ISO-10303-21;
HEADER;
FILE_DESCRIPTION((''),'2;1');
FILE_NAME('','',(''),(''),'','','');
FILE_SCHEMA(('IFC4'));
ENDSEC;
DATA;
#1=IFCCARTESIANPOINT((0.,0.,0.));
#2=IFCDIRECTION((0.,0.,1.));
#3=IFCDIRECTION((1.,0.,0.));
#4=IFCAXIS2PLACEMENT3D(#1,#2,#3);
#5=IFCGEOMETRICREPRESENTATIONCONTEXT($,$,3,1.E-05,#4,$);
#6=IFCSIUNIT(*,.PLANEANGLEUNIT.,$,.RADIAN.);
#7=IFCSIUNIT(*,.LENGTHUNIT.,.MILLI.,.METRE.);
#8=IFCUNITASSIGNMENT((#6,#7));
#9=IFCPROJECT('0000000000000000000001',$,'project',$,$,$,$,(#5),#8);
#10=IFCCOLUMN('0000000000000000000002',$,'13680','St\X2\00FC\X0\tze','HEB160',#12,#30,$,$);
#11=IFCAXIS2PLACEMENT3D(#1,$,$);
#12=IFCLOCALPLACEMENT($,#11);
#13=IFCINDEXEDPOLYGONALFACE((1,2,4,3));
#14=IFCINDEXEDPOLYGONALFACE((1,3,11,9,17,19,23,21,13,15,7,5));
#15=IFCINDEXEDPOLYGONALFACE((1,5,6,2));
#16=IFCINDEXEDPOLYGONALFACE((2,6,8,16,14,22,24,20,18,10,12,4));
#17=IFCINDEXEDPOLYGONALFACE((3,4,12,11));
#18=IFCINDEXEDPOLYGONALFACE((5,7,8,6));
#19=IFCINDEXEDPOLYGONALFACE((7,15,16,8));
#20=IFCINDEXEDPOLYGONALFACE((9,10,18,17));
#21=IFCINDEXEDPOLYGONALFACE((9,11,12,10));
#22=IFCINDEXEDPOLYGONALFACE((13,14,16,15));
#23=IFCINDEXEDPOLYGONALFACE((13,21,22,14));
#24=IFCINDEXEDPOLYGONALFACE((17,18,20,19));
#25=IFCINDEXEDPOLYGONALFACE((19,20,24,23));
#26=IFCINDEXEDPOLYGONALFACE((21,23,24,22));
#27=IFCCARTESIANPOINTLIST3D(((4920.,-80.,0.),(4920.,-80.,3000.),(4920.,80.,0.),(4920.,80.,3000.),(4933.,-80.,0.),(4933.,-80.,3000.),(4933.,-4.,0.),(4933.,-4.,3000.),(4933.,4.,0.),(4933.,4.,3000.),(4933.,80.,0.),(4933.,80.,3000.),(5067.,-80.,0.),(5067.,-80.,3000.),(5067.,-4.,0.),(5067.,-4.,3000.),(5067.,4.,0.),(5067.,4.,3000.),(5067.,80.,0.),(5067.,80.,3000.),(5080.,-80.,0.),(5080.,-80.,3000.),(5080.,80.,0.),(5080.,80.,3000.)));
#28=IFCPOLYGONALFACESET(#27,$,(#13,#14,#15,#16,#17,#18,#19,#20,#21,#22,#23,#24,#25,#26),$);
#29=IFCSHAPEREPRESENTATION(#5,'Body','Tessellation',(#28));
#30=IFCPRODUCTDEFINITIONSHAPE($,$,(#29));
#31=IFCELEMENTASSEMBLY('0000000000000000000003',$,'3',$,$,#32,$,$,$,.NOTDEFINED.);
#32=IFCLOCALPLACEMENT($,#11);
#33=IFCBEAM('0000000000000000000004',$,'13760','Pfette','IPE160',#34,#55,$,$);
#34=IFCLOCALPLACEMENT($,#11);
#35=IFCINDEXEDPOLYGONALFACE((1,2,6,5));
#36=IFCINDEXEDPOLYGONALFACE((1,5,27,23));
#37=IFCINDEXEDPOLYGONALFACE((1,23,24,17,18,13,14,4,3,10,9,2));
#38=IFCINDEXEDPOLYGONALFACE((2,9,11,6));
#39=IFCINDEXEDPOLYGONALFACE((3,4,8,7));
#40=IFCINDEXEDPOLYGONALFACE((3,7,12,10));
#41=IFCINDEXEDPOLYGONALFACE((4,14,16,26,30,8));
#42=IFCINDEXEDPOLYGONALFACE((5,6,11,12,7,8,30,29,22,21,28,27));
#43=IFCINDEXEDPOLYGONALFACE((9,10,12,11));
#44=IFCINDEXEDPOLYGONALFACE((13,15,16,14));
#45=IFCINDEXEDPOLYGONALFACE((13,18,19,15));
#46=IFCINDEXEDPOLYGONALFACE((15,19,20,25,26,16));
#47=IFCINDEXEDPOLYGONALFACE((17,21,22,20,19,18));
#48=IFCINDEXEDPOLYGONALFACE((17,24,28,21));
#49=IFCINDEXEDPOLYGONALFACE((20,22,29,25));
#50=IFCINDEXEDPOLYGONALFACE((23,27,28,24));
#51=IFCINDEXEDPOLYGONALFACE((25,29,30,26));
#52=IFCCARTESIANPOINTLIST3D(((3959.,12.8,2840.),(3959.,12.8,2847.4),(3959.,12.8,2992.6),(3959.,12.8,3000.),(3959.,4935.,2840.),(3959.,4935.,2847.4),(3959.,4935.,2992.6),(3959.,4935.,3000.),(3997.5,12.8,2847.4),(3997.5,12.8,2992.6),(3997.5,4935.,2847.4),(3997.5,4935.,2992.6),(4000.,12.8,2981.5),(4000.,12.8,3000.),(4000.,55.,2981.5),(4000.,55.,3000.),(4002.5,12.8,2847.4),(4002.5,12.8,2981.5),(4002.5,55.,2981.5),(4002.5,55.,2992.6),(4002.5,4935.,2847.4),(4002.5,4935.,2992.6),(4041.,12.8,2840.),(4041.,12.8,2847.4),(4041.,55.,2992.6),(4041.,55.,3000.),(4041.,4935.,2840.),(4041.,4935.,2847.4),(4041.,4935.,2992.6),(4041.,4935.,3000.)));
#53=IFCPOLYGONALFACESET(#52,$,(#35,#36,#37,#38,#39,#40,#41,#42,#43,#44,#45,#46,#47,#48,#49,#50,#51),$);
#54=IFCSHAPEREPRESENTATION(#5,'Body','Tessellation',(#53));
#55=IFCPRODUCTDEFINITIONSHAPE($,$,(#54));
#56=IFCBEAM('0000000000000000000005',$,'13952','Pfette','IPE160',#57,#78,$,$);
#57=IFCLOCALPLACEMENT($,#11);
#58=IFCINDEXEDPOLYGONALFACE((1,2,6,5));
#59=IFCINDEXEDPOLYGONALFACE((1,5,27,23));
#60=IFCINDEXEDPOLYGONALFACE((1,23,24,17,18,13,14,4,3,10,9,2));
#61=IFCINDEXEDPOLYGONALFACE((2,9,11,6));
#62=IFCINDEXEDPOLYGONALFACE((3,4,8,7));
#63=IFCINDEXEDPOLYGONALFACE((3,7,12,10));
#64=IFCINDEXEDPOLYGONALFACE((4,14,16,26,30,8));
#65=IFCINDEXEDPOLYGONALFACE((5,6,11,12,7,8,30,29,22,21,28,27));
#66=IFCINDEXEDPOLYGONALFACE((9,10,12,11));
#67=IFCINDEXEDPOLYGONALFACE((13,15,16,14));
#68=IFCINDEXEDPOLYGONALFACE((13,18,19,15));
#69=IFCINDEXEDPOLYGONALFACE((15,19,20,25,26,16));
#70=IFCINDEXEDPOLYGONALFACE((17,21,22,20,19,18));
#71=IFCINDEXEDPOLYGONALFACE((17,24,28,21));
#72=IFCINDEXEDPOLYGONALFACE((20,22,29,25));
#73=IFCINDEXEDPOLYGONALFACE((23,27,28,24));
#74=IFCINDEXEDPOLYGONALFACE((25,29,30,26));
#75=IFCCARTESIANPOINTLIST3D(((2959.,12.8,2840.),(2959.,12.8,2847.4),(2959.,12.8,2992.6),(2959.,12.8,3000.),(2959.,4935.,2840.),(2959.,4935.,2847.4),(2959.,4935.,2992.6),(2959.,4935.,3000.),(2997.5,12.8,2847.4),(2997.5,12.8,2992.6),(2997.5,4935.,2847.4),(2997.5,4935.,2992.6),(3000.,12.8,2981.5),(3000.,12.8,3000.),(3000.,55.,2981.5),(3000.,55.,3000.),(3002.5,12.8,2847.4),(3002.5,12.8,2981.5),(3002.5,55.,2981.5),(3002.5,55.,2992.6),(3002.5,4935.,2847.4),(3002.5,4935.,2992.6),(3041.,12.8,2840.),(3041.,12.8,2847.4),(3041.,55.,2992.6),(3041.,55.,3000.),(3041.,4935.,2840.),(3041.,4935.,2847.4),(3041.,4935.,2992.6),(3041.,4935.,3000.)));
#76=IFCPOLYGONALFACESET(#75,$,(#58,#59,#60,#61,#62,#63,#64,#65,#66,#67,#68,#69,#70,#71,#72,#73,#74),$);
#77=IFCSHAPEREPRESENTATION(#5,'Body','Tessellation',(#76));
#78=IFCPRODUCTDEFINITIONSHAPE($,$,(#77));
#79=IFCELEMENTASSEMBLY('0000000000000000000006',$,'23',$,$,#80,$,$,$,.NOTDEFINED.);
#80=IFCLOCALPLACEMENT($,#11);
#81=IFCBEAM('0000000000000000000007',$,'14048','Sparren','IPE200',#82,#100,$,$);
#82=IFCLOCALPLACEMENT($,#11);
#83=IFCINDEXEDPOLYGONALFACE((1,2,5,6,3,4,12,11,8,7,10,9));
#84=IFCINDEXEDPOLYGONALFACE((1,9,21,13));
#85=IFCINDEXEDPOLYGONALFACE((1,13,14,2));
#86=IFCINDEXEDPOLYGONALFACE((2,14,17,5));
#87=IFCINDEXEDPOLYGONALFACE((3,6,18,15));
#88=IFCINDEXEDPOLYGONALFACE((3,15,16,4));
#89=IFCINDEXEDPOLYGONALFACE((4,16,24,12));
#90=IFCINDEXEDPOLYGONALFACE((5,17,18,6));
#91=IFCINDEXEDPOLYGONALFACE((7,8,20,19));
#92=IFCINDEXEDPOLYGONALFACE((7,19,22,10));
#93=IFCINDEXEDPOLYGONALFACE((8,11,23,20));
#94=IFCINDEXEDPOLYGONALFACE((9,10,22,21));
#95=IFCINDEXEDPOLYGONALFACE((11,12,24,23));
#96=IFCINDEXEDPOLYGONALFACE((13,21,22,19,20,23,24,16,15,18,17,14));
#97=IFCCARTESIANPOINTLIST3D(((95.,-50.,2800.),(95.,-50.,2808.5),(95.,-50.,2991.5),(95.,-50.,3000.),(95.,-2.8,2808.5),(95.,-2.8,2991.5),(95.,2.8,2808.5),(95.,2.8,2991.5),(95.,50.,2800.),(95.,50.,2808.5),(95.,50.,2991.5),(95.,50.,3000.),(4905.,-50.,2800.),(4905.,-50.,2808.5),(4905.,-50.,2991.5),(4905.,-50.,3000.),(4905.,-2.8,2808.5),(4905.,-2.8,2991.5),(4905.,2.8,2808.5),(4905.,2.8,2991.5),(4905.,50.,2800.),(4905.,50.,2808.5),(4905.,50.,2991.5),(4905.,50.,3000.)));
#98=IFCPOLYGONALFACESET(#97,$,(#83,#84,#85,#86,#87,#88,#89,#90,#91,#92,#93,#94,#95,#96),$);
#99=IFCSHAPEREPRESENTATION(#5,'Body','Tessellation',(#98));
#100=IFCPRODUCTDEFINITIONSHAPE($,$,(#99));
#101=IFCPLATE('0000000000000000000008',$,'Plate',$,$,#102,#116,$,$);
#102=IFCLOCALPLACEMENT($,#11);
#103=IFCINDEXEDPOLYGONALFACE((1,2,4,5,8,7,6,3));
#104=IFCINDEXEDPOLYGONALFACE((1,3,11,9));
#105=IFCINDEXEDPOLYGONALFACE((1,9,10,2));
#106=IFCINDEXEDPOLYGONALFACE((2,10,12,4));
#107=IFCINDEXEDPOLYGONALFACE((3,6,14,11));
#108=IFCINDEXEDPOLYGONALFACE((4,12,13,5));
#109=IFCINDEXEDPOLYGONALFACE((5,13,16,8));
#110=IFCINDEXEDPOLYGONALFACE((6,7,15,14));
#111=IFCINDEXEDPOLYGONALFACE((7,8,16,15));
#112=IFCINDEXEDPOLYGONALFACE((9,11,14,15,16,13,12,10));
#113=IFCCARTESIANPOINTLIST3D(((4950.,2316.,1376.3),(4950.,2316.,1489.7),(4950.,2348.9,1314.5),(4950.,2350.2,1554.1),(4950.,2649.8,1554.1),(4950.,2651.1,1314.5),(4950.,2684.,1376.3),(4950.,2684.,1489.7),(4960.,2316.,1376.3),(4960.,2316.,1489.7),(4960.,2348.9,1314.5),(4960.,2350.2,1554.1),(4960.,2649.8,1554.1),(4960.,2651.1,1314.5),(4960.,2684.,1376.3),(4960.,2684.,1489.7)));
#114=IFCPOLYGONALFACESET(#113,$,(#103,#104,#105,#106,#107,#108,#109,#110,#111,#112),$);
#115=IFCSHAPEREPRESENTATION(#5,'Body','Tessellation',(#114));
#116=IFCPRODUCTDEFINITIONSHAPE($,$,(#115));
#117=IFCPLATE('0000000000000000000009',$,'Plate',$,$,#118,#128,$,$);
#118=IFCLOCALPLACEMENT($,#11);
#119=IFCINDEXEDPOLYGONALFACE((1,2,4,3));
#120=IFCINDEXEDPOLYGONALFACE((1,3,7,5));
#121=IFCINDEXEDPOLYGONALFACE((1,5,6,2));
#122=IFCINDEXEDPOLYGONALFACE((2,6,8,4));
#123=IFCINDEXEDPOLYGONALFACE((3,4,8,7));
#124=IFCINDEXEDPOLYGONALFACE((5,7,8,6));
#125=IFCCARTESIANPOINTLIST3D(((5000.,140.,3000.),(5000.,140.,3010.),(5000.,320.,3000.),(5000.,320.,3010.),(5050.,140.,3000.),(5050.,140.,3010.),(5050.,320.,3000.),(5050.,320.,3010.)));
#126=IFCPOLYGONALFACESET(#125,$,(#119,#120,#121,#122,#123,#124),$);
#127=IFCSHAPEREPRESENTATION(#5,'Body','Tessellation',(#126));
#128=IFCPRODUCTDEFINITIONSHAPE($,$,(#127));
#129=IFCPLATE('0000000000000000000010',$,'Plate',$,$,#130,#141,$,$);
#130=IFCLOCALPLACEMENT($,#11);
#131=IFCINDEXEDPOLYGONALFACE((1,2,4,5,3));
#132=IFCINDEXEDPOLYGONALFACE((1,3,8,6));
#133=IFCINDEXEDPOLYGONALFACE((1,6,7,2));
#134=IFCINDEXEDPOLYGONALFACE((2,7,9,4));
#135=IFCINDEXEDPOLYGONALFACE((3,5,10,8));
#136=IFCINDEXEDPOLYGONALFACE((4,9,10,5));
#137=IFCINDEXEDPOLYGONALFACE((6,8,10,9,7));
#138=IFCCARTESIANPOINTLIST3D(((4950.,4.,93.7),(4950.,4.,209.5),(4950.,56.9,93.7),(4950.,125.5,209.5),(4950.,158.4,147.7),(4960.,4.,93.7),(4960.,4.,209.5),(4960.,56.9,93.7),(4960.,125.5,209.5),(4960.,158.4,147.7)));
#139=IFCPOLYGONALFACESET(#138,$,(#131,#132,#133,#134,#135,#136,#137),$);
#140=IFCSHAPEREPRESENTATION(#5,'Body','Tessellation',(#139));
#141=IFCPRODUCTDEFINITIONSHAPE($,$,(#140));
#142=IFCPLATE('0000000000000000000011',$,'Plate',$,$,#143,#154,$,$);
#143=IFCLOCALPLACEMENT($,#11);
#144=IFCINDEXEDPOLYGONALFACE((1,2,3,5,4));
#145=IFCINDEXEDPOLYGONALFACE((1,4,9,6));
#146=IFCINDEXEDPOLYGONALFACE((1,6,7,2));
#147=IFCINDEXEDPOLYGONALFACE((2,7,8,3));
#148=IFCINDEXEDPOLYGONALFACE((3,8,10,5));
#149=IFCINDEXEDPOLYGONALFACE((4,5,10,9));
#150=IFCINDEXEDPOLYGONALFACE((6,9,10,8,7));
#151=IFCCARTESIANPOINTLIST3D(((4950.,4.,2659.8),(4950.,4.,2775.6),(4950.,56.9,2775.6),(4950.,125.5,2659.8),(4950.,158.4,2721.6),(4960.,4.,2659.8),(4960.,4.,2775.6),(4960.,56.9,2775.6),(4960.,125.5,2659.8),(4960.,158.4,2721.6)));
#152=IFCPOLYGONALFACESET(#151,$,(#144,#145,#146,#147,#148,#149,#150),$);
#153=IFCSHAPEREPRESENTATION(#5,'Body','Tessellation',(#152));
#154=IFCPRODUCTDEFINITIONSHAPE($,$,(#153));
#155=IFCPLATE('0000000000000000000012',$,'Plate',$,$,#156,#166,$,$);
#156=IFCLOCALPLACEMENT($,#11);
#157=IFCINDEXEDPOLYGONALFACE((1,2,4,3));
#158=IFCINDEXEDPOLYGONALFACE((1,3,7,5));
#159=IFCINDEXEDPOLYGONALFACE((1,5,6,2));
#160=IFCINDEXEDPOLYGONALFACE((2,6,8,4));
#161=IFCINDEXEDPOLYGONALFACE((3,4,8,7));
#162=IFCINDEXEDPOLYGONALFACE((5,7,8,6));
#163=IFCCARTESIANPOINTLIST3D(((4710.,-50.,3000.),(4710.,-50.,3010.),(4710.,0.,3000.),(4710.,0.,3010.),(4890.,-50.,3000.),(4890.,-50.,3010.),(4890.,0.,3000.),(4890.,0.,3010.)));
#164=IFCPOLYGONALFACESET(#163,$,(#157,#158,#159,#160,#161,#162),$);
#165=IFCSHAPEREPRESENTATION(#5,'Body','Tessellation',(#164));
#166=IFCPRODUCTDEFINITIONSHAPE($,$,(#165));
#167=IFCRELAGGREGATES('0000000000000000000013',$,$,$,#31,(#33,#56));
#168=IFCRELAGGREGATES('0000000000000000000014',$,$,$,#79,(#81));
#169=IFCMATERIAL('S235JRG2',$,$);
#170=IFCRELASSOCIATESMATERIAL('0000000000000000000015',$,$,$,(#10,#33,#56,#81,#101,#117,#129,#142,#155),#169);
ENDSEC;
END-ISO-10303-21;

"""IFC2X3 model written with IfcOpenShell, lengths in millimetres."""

from ifc_helpers import new_model, si_unit, point, frame, origin_with_axes, place, context, project, polyline, line_curve, trimmed, segment, composite_curve, outline, extrude, clip, halfspace, material, element, aggregate, save


model = new_model("IFC2X3")

# Units and contexts
context_of_model = context(None, 3, precision=1e-05, world=origin_with_axes())
ifc_project = project(units=[si_unit("PLANEANGLEUNIT", "RADIAN"), si_unit("LENGTHUNIT", "METRE", prefix="MILLI")], contexts=[context_of_model])

# Column
ifc_material = material(Name="S235JRG2")
placement_1 = place(None, frame((5000.0, 0.0, 3000.0), z_axis=(1.0, 0.0, 0.0), x_axis=(0.0, 0.0, -1.0)))
column_placement = place(placement_1, origin_with_axes())
element("IfcColumn", 1, at=column_placement, material=ifc_material, Name="13680", Description="Stütze", ObjectType="HEB160", context=context_of_model, shape_type="Clipping", body=[
    clip(extrude(outline(polyline([(80.0, -80.0), (80.0, -67.0), (4.0, -67.0), (4.0, 67.0), (80.0, 67.0), (80.0, 80.0), (-80.0, 80.0), (-80.0, 67.0), (-4.0, 67.0), (-4.0, -67.0), (-80.0, -67.0), (-80.0, -80.0), (80.0, -80.0), (80.0, -80.0)])), frame((0.0, 0.0, 0.0), z_axis=(1.0, 0.0, 0.0), x_axis=(0.0, 1.0, 0.0)), (0.0, 0.0, 1.0), 3000.0), halfspace(frame((3000.0, 0.0, 0.0), z_axis=(1.0, 0.0, 0.0), x_axis=(0.0, 0.0, 1.0)), False)),
])

# Element assembly, beams, openings
assembly_1_placement = place(None, frame((1000.0, 5002.5, 6000.0), z_axis=(0.0, 0.0, 1.0), x_axis=(0.0, 1.0, 0.0)))
assembly_1 = element("IfcElementAssembly", 2, at=assembly_1_placement, Name="3", PredefinedType="NOTDEFINED")
placement_2 = place(None, frame((4000.0, 0.0, 2920.0), z_axis=(0.0, 0.0, 1.0), x_axis=(0.0, 1.0, 0.0)))
beam_1_placement = place(placement_2, origin_with_axes())
beam_1 = element("IfcBeam", 3, at=beam_1_placement, material=ifc_material, Name="13760", Description="Pfette", ObjectType="IPE160", context=context_of_model, shape_type="Clipping", body=[
    clip(clip(extrude(outline(polyline([(41.0, -80.0), (41.0, -72.6), (2.5, -72.6), (2.5, 72.6), (41.0, 72.6), (41.0, 80.0), (-41.0, 80.0), (-41.0, 72.6), (-2.5, 72.6), (-2.5, -72.6), (-41.0, -72.6), (-41.0, -80.0), (41.0, -80.0), (41.0, -80.0)])), frame((0.0, 0.0, 0.0), z_axis=(1.0, 0.0, 0.0), x_axis=(0.0, 1.0, 0.0)), (0.0, 0.0, 1.0), 4997.5), halfspace(frame((12.8, 0.0, 80.0), z_axis=(-1.0, 0.0, 0.0), x_axis=(0.0, 0.0, -1.0)), False)), halfspace(frame((4935.0, 0.0, 80.0), z_axis=(1.0, 0.0, 0.0), x_axis=(0.0, 0.0, 1.0)), False)),
])
opening_1_placement = place(beam_1_placement, frame((55.0, 0.0, 61.5), z_axis=(0.0, -1.0, 0.0), x_axis=(1.0, 0.0, 0.0)))
element("IfcOpeningElement", 4, at=opening_1_placement, cuts=beam_1, ObjectType="Recess", context=context_of_model, shape_type="SweptSolid", body=[
    extrude(outline(composite_curve([segment(trimmed(line_curve((0.0, 0.0), (0.0, 1.0, 0.0), 18.501), [point((0.0, 0.0))], [point((0.0, 18.5))], True, "CARTESIAN"), True, "CONTINUOUS"), segment(trimmed(line_curve((0.0, 18.5), (-1.0, 0.0, 0.0), 42.201), [point((0.0, 18.5))], [point((-42.2, 18.5))], True, "CARTESIAN"), True, "CONTINUOUS"), segment(trimmed(line_curve((-42.2, 18.5), (0.0, -1.0, 0.0), 18.501), [point((-42.2, 18.5))], [point((-42.2, 0.0))], True, "CARTESIAN"), True, "CONTINUOUS"), segment(trimmed(line_curve((-42.2, 0.0), (1.0, 0.0, 0.0), 42.201), [point((-42.2, 0.0))], [point((0.0, 0.0))], True, "CARTESIAN"), True, "CONTINUOUS")], self_intersect=False)), origin_with_axes(), (0.0, 0.0, 1.0), 3000.0),
])
placement_3 = place(None, frame((3000.0, 0.0, 2920.0), z_axis=(0.0, 0.0, 1.0), x_axis=(0.0, 1.0, 0.0)))
beam_2_placement = place(placement_3, origin_with_axes())
beam_2 = element("IfcBeam", 5, at=beam_2_placement, material=ifc_material, Name="13952", Description="Pfette", ObjectType="IPE160", context=context_of_model, shape_type="Clipping", body=[
    clip(clip(extrude(outline(polyline([(41.0, -80.0), (41.0, -72.6), (2.5, -72.6), (2.5, 72.6), (41.0, 72.6), (41.0, 80.0), (-41.0, 80.0), (-41.0, 72.6), (-2.5, 72.6), (-2.5, -72.6), (-41.0, -72.6), (-41.0, -80.0), (41.0, -80.0), (41.0, -80.0)])), frame((0.0, 0.0, 0.0), z_axis=(1.0, 0.0, 0.0), x_axis=(0.0, 1.0, 0.0)), (0.0, 0.0, 1.0), 4997.5), halfspace(frame((12.8, 0.0, 80.0), z_axis=(-1.0, 0.0, 0.0), x_axis=(0.0, 0.0, -1.0)), False)), halfspace(frame((4935.0, 0.0, 80.0), z_axis=(1.0, 0.0, 0.0), x_axis=(0.0, 0.0, 1.0)), False)),
])
opening_2_placement = place(beam_2_placement, frame((55.0, 0.0, 61.5), z_axis=(0.0, -1.0, 0.0), x_axis=(1.0, 0.0, 0.0)))
element("IfcOpeningElement", 6, at=opening_2_placement, cuts=beam_2, ObjectType="Recess", context=context_of_model, shape_type="SweptSolid", body=[
    extrude(outline(composite_curve([segment(trimmed(line_curve((0.0, 0.0), (0.0, 1.0, 0.0), 18.501), [point((0.0, 0.0))], [point((0.0, 18.5))], True, "CARTESIAN"), True, "CONTINUOUS"), segment(trimmed(line_curve((0.0, 18.5), (-1.0, 0.0, 0.0), 42.201), [point((0.0, 18.5))], [point((-42.2, 18.5))], True, "CARTESIAN"), True, "CONTINUOUS"), segment(trimmed(line_curve((-42.2, 18.5), (0.0, -1.0, 0.0), 18.501), [point((-42.2, 18.5))], [point((-42.2, 0.0))], True, "CARTESIAN"), True, "CONTINUOUS"), segment(trimmed(line_curve((-42.2, 0.0), (1.0, 0.0, 0.0), 42.201), [point((-42.2, 0.0))], [point((0.0, 0.0))], True, "CARTESIAN"), True, "CONTINUOUS")], self_intersect=False)), origin_with_axes(), (0.0, 0.0, 1.0), 3000.0),
])
aggregate(assembly_1, [beam_1, beam_2])

# Element assembly, beam
assembly_2_placement = place(None, frame((5000.0, 0.0, 3000.0), z_axis=(0.0, 0.0, 1.0), x_axis=(-1.0, 0.0, 0.0)))
assembly_2 = element("IfcElementAssembly", 7, at=assembly_2_placement, Name="23", PredefinedType="NOTDEFINED")
placement_4 = place(None, frame((5000.0, 0.0, 2900.0), z_axis=(0.0, 0.0, 1.0), x_axis=(-1.0, 0.0, 0.0)))
beam_3_placement = place(placement_4, origin_with_axes())
beam_3 = element("IfcBeam", 8, at=beam_3_placement, material=ifc_material, Name="14048", Description="Sparren", ObjectType="IPE200", context=context_of_model, shape_type="Clipping", body=[
    clip(clip(extrude(outline(polyline([(50.0, -100.0), (50.0, -91.5), (2.8, -91.5), (2.8, 91.5), (50.0, 91.5), (50.0, 100.0), (-50.0, 100.0), (-50.0, 91.5), (-2.8, 91.5), (-2.8, -91.5), (-50.0, -91.5), (-50.0, -100.0), (50.0, -100.0), (50.0, -100.0)])), frame((0.0, 0.0, 0.0), z_axis=(1.0, 0.0, 0.0), x_axis=(0.0, 1.0, 0.0)), (0.0, 0.0, 1.0), 5000.0), halfspace(frame((95.0, 0.0, 100.0), z_axis=(-1.0, 0.0, 0.0), x_axis=(0.0, 0.0, -1.0)), False)), halfspace(frame((4905.0, 0.0, 100.0), z_axis=(1.0, 0.0, 0.0), x_axis=(0.0, 0.0, 1.0)), False)),
])
aggregate(assembly_2, [beam_3])

# Plates
placement_5 = place(None, frame((4950.0, 2684.0, 1376.3), z_axis=(0.0, -1.0, 0.0), x_axis=(1.0, 0.0, 0.0)))
plate_1_placement = place(placement_5, origin_with_axes())
element("IfcPlate", 9, at=plate_1_placement, material=ifc_material, Name="Plate", context=context_of_model, shape_type="SweptSolid", body=[
    extrude(outline(polyline([(0.0, 0.0), (113.4, 0.0), (177.8, 34.3), (177.8, 333.8), (113.4, 368.1), (0.0, 368.1), (-61.8, 335.2), (-61.8, 32.9), (0.0, 0.0)])), frame((0.0, 0.0, 0.0), z_axis=(1.0, 0.0, 0.0), x_axis=(0.0, 1.0, 0.0)), (0.0, 0.0, 1.0), 10.0),
])
placement_6 = place(None, origin_with_axes())
plate_2_placement = place(placement_6, frame((5000.0, 140.0, 3010.0), z_axis=(1.0, 0.0, 0.0), x_axis=(0.0, 0.0, -1.0)))
element("IfcPlate", 10, at=plate_2_placement, material=ifc_material, Name="Plate", context=context_of_model, shape_type="SweptSolid", body=[
    extrude(outline(polyline([(0.0, 0.0), (180.0, 0.0), (180.0, 50.0), (0.0, 50.0), (0.0, 0.0)])), frame((0.0, 0.0, 0.0), z_axis=(1.0, 0.0, 0.0), x_axis=(0.0, 1.0, 0.0)), (0.0, 0.0, 1.0), 10.0),
])
placement_7 = place(None, origin_with_axes())
plate_3_placement = place(placement_7, frame((4960.0, 56.9, 93.7), z_axis=(0.0, 0.0, 1.0), x_axis=(-1.0, 0.0, 0.0)))
element("IfcPlate", 11, at=plate_3_placement, material=ifc_material, Name="Plate", context=context_of_model, shape_type="SweptSolid", body=[
    extrude(outline(polyline([(0.0, 0.0), (52.9, 0.0), (52.9, 115.8), (-68.6, 115.8), (-101.5, 54.1), (0.0, 0.0)])), frame((0.0, 0.0, 0.0), z_axis=(1.0, 0.0, 0.0), x_axis=(0.0, 1.0, 0.0)), (0.0, 0.0, 1.0), 10.0),
])
placement_8 = place(None, origin_with_axes())
plate_4_placement = place(placement_8, frame((4950.0, 56.9, 2775.6), z_axis=(0.0, 0.0, -1.0), x_axis=(1.0, 0.0, 0.0)))
element("IfcPlate", 12, at=plate_4_placement, material=ifc_material, Name="Plate", context=context_of_model, shape_type="SweptSolid", body=[
    extrude(outline(polyline([(0.0, 0.0), (52.9, 0.0), (52.9, 115.8), (-68.6, 115.8), (-101.5, 54.1), (0.0, 0.0)])), frame((0.0, 0.0, 0.0), z_axis=(1.0, 0.0, 0.0), x_axis=(0.0, 1.0, 0.0)), (0.0, 0.0, 1.0), 10.0),
])
placement_9 = place(None, origin_with_axes())
plate_5_placement = place(placement_9, frame((4890.0, -50.0, 3010.0), z_axis=(0.0, 1.0, 0.0), x_axis=(0.0, 0.0, -1.0)))
element("IfcPlate", 13, at=plate_5_placement, material=ifc_material, Name="Plate", context=context_of_model, shape_type="SweptSolid", body=[
    extrude(outline(polyline([(0.0, 0.0), (180.0, 0.0), (180.0, 50.0), (0.0, 50.0), (0.0, 0.0)])), frame((0.0, 0.0, 0.0), z_axis=(1.0, 0.0, 0.0), x_axis=(0.0, 1.0, 0.0)), (0.0, 0.0, 1.0), 10.0),
])

save(model, "model.ifc")
